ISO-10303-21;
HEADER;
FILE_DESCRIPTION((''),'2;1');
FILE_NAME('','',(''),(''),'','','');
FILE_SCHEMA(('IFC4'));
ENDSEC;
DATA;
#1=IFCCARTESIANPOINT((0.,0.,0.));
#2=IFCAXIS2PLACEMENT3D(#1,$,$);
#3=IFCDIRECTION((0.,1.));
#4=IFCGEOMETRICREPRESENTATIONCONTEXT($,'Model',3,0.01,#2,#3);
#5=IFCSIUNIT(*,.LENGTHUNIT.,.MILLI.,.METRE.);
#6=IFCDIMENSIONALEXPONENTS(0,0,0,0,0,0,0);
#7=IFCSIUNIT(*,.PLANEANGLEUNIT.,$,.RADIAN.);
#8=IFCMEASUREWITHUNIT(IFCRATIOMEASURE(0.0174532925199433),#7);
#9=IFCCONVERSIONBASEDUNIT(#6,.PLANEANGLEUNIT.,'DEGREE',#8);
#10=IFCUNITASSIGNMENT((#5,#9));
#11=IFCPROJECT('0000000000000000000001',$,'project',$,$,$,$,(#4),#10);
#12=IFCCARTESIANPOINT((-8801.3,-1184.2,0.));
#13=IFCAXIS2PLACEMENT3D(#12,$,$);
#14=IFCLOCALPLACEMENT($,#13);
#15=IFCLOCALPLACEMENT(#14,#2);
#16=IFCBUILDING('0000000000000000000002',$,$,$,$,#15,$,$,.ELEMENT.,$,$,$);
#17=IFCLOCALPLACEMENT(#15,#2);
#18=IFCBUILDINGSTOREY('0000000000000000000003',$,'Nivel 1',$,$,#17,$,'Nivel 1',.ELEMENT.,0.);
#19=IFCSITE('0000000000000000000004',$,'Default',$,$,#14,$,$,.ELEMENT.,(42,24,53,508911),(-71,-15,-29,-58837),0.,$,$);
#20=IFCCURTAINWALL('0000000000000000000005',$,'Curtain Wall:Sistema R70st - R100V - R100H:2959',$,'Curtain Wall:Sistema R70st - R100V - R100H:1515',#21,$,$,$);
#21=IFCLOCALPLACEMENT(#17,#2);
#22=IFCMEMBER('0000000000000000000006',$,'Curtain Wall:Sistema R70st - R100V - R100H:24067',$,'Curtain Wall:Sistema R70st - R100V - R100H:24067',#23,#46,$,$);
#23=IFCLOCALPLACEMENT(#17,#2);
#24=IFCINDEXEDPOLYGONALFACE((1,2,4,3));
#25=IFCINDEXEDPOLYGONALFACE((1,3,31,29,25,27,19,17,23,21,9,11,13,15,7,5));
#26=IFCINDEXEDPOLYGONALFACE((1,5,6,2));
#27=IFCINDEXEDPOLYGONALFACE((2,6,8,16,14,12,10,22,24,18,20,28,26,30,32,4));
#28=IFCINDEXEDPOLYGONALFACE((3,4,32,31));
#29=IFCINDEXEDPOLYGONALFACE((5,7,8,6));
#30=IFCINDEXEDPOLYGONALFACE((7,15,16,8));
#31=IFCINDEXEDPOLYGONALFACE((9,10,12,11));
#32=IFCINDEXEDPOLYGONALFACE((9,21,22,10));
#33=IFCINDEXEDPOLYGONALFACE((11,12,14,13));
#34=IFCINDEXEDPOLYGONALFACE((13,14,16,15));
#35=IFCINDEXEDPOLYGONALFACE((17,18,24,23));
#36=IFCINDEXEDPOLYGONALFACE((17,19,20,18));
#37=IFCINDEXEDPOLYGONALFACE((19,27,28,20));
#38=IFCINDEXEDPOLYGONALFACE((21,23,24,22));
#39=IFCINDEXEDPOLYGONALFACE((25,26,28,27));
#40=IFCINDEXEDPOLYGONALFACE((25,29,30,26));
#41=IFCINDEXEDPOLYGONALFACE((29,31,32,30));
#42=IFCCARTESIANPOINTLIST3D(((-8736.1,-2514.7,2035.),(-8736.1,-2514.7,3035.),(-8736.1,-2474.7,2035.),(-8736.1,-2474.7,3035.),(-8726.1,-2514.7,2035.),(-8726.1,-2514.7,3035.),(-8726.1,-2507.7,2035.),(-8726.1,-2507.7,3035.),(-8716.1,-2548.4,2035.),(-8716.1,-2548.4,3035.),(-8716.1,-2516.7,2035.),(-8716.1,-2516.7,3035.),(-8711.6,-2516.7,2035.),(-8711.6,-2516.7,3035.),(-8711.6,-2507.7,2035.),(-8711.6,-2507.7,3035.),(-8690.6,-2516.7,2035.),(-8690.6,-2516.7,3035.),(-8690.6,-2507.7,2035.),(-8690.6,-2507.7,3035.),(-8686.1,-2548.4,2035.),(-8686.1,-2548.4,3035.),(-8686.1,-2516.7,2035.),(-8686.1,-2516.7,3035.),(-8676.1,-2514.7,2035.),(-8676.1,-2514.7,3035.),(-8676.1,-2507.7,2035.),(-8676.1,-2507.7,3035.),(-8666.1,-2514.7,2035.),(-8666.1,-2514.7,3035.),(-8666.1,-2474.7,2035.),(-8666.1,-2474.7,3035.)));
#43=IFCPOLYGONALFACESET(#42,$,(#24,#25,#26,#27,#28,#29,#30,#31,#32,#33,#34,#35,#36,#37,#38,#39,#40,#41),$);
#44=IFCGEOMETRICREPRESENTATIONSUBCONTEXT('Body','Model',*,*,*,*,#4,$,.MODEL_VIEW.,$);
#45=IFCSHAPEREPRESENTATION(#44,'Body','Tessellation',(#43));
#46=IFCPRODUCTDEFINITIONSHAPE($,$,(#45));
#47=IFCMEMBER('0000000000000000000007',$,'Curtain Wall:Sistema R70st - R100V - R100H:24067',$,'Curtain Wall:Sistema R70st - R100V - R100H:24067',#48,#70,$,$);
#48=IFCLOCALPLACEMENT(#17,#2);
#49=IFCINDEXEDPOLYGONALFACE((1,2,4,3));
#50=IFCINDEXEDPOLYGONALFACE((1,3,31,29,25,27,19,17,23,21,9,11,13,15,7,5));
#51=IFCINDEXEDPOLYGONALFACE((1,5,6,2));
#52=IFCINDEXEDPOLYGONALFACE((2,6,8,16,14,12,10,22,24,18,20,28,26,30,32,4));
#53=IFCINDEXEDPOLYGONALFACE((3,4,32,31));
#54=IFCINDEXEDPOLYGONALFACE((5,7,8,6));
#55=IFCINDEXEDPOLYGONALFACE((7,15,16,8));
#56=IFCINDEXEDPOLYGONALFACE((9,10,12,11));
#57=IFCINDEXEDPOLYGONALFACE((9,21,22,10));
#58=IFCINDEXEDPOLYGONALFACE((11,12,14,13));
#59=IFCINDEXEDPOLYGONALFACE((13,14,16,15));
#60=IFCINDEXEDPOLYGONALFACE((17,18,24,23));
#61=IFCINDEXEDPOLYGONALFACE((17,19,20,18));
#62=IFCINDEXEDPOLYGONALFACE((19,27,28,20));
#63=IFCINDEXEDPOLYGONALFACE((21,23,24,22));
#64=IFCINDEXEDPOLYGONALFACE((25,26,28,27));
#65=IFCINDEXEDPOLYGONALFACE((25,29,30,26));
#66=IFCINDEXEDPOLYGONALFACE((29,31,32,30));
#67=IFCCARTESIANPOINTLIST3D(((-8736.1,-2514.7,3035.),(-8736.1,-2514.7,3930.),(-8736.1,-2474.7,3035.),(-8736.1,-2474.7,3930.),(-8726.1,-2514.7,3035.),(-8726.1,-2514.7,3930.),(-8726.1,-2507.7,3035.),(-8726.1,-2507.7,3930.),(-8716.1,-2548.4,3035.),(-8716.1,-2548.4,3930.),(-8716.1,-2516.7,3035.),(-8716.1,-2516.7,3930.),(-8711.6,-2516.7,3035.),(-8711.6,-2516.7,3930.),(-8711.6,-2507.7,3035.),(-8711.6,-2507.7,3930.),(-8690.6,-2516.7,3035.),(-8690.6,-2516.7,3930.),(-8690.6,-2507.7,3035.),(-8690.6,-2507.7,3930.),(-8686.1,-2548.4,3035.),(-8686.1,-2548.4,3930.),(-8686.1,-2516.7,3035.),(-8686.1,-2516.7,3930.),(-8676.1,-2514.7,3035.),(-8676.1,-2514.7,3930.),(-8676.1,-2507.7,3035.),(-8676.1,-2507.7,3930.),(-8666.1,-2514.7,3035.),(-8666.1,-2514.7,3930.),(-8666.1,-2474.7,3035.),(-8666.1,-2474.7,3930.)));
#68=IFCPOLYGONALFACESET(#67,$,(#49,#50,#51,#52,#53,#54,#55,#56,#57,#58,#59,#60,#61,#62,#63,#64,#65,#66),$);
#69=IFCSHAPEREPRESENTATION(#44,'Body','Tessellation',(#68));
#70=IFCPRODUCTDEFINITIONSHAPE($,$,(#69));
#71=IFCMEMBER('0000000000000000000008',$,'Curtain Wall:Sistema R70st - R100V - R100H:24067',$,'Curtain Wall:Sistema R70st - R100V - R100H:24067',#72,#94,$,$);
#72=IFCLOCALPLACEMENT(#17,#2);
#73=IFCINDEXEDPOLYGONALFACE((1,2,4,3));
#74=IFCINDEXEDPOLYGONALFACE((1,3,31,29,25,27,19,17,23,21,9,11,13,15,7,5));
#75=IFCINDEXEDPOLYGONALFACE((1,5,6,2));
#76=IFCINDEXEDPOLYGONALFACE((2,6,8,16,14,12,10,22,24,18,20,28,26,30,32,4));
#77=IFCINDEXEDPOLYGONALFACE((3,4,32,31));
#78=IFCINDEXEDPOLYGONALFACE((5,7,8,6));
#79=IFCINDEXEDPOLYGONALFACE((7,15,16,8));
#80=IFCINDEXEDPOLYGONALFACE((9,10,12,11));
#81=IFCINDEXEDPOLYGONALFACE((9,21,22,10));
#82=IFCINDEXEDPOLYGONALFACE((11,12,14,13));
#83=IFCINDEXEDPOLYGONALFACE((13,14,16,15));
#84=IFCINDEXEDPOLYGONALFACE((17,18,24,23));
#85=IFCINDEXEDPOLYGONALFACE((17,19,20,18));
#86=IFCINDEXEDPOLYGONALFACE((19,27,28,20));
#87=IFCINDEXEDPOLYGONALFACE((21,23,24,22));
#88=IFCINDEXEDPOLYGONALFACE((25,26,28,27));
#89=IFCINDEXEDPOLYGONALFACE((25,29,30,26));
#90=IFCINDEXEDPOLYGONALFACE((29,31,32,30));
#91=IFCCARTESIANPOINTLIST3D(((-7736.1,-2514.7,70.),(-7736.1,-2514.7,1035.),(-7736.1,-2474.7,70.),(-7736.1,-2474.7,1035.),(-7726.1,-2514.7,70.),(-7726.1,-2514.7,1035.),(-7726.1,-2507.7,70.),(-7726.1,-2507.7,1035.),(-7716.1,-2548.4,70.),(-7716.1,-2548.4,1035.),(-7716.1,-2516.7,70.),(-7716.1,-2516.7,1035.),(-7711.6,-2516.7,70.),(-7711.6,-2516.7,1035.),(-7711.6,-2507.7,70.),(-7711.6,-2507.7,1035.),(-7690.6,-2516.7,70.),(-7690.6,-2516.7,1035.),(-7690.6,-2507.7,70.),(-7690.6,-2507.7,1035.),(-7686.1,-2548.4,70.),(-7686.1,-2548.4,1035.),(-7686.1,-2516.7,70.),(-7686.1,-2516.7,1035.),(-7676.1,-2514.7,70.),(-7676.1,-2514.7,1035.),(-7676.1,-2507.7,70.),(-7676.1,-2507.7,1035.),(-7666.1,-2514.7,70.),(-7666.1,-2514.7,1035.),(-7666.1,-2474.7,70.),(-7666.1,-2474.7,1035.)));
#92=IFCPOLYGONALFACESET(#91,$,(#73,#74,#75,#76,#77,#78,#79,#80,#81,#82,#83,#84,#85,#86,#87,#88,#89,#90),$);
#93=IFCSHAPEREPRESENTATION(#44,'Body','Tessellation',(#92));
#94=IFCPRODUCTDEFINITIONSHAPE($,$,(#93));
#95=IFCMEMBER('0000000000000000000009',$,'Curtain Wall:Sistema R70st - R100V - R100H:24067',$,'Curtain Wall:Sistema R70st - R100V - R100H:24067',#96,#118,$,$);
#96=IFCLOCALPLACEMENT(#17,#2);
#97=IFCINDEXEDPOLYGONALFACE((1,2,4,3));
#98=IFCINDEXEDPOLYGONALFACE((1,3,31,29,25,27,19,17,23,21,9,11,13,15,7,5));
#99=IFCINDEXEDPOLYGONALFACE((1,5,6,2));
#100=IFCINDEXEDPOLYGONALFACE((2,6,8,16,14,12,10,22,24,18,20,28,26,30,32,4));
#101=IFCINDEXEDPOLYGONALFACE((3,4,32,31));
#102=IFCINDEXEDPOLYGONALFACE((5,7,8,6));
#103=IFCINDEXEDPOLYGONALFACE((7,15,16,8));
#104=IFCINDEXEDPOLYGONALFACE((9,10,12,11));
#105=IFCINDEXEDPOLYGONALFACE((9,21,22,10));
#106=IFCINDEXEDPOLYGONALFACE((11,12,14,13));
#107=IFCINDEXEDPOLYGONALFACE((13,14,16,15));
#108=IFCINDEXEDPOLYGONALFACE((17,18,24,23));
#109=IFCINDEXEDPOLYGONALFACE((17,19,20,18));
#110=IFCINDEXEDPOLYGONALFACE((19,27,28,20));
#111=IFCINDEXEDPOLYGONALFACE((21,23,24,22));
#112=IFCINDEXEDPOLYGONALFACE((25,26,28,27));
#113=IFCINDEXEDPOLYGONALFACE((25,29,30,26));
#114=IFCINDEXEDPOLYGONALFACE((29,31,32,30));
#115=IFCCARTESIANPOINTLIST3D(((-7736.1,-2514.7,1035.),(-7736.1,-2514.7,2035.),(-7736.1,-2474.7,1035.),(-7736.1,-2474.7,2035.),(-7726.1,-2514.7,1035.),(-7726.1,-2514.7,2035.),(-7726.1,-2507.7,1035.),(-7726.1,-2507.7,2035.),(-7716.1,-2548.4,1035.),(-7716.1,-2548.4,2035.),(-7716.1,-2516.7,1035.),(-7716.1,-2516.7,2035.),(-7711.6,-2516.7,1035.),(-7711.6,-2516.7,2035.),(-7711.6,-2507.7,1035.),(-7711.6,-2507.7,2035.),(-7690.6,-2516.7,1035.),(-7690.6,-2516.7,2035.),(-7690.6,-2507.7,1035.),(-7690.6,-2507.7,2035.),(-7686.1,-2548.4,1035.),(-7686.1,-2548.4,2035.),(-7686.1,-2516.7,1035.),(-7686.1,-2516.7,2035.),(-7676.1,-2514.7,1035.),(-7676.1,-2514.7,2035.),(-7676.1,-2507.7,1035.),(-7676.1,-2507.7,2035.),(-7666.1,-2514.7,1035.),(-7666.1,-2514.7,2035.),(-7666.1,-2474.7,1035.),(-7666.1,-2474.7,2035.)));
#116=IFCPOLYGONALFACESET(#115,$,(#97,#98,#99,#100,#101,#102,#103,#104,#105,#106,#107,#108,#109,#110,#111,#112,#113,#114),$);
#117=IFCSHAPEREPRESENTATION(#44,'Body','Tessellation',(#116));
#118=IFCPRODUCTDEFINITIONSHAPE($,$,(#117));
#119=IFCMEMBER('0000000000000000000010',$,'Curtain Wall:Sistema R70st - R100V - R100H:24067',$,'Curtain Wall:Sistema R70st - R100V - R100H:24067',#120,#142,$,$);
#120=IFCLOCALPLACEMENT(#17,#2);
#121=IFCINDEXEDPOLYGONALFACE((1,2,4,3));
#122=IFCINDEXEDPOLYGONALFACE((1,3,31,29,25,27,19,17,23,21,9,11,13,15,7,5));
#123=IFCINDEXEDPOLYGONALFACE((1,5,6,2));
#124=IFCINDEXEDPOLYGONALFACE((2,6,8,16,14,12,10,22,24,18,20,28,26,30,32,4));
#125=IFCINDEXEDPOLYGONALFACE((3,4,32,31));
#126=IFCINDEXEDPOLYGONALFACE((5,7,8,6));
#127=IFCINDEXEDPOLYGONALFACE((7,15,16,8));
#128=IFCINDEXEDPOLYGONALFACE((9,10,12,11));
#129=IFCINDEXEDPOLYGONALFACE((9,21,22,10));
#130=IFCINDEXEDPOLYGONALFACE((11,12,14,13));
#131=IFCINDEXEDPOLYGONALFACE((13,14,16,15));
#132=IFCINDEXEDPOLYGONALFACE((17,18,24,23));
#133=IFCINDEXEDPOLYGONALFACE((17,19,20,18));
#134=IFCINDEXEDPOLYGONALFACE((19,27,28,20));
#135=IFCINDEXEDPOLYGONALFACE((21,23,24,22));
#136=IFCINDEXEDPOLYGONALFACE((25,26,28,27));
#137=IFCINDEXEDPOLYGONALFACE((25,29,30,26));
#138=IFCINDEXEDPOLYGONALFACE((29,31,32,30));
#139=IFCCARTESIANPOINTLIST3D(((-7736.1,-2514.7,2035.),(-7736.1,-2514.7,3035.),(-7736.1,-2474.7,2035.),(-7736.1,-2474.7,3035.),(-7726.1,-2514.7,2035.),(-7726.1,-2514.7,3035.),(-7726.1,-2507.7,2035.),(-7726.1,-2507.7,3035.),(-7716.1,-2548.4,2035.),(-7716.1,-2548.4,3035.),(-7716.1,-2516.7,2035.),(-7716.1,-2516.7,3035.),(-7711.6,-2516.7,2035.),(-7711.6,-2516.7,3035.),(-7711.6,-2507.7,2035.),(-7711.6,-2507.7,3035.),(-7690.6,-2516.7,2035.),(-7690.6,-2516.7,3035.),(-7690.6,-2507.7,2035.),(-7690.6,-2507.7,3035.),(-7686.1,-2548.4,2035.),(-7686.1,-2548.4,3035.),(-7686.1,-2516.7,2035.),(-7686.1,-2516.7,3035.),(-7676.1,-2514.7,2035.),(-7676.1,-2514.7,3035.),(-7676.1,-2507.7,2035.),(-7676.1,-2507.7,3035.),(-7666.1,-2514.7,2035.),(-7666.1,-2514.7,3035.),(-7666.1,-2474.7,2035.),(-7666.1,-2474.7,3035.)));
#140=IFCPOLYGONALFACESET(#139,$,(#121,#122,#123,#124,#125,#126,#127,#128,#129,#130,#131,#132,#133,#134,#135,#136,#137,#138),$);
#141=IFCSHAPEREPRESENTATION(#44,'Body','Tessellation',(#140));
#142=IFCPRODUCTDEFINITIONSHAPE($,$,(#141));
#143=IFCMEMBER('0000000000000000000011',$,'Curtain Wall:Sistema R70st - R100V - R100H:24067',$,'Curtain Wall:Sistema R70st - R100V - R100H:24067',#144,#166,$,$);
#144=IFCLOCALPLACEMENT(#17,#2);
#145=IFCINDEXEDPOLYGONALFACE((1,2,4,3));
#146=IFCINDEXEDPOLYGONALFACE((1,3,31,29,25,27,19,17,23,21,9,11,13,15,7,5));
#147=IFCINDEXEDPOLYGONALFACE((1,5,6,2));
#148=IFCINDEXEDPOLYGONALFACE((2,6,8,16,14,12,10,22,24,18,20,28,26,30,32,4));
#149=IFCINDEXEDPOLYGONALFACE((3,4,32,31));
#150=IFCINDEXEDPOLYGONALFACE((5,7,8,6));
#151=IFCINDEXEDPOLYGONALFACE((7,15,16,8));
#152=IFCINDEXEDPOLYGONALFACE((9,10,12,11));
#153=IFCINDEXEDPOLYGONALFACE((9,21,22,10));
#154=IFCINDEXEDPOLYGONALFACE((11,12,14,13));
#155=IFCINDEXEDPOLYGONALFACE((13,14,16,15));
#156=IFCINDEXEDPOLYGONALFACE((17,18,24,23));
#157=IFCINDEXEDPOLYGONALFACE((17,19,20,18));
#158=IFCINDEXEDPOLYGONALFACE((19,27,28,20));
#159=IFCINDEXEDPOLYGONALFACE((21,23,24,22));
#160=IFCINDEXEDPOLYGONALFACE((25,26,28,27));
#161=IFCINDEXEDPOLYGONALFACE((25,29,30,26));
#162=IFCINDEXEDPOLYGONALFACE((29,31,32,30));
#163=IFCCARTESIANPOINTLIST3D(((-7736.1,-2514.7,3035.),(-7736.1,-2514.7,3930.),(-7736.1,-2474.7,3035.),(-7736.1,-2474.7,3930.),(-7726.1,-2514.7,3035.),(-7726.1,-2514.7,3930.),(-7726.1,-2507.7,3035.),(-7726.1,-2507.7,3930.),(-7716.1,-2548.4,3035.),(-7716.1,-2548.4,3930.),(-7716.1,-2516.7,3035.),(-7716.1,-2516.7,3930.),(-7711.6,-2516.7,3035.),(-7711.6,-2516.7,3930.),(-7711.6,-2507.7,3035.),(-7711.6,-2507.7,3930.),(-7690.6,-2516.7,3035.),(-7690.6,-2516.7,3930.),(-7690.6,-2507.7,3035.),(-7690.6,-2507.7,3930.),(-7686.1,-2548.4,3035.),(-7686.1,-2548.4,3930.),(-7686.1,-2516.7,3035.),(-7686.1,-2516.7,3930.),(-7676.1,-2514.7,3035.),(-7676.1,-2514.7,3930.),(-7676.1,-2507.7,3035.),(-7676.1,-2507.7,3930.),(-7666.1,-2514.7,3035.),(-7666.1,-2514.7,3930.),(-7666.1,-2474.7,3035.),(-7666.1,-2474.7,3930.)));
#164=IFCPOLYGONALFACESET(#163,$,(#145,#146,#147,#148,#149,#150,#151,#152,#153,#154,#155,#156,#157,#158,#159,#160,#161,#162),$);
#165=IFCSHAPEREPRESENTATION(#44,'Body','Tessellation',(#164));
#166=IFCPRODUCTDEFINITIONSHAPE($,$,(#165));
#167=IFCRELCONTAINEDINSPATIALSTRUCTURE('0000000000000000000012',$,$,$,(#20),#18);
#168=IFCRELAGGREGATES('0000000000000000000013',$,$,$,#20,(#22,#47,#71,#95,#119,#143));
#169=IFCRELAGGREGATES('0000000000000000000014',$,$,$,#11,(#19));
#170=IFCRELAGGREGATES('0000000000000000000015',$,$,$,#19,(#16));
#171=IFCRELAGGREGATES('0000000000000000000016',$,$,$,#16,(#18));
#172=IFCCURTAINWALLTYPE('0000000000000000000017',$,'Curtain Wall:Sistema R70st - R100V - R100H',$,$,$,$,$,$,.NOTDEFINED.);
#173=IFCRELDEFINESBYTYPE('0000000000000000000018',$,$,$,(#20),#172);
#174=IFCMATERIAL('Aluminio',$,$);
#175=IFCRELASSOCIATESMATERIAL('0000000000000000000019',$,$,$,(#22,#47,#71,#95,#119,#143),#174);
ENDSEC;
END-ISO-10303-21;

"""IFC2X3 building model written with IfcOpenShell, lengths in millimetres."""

from ifc_helpers import new_model, entity, si_unit, converted_unit, direction, frame, origin, place, context, subcontext, project, spatial, polyline, outline, extrude, material, type_object, element, aggregate, save


model = new_model("IFC2X3")

# Units and contexts
model_context = context("Model", 3, precision=0.01, world=origin(), true_north=direction((0.0, 1.0)))
body_context = subcontext(model_context, "Body", "Model", "MODEL_VIEW")
ifc_project = project(units=[si_unit("LENGTHUNIT", "METRE", prefix="MILLI"), converted_unit("PLANEANGLEUNIT", "DEGREE", entity("IfcRatioMeasure", 0.0174532925199433), si_unit("PLANEANGLEUNIT", "RADIAN"), dimensions=[0, 0, 0, 0, 0, 0, 0])], contexts=[model_context])

# Site, building, storey
site_placement = place(None, frame((-8801.3, -1184.2, 0.0)))
site = spatial("IfcSite", under=ifc_project, at=site_placement, Name="Default", CompositionType="ELEMENT", RefLatitude=(42, 24, 53, 508911), RefLongitude=(-71, -15, -29, -58837), RefElevation=0.0)
building_placement = place(site_placement, origin())
building = spatial("IfcBuilding", under=site, at=building_placement, CompositionType="ELEMENT")
storey_placement = place(building_placement, origin())
storey = spatial("IfcBuildingStorey", under=building, at=storey_placement, Name="Nivel 1", LongName="Nivel 1", CompositionType="ELEMENT", Elevation=0.0)

# Curtain wall, members
curtain_wall_type = type_object("IfcCurtainWallType", Name="Curtain Wall:Sistema R70st - R100V - R100H", PredefinedType="NOTDEFINED")
curtain_wall_placement = place(storey_placement, origin())
curtain_wall = element("IfcCurtainWall", 1, at=curtain_wall_placement, inside=storey, type_object=curtain_wall_type, Name="Curtain Wall:Sistema R70st - R100V - R100H:2959", ObjectType="Curtain Wall:Sistema R70st - R100V - R100H:1515")
ifc_material = material(Name="Aluminio")
member_1_placement = place(curtain_wall_placement, origin())
member_1 = element("IfcMember", 2, at=member_1_placement, material=ifc_material, Name="Curtain Wall:Sistema R70st - R100V - R100H:24067", ObjectType="Curtain Wall:Sistema R70st - R100V - R100H:24067", context=body_context, shape_type="SweptSolid", body=[
    extrude(outline(polyline([(-35.0, -38.0), (35.0, -38.0), (35.0, 2.0), (25.0, 2.0), (25.0, -5.0), (10.5, -5.0), (10.5, 4.0), (15.0, 4.0), (15.0, 35.7), (-15.0, 35.7), (-15.0, 4.0), (-10.5, 4.0), (-10.5, -5.0), (-25.0, -5.0), (-25.0, 2.0), (-35.0, 2.0), (-35.0, -38.0)])), frame((-8701.1, -2512.7, 2035.0), z_axis=(0.0, 0.0, 1.0), x_axis=(-1.0, 0.0, 0.0)), (0.0, 0.0, 1.0), 1000.0),
])
member_2_placement = place(curtain_wall_placement, origin())
member_2 = element("IfcMember", 3, at=member_2_placement, material=ifc_material, Name="Curtain Wall:Sistema R70st - R100V - R100H:24067", ObjectType="Curtain Wall:Sistema R70st - R100V - R100H:24067", context=body_context, shape_type="SweptSolid", body=[
    extrude(outline(polyline([(-35.0, -38.0), (35.0, -38.0), (35.0, 2.0), (25.0, 2.0), (25.0, -5.0), (10.5, -5.0), (10.5, 4.0), (15.0, 4.0), (15.0, 35.7), (-15.0, 35.7), (-15.0, 4.0), (-10.5, 4.0), (-10.5, -5.0), (-25.0, -5.0), (-25.0, 2.0), (-35.0, 2.0), (-35.0, -38.0)])), frame((-8701.1, -2512.7, 3035.0), z_axis=(0.0, 0.0, 1.0), x_axis=(-1.0, 0.0, 0.0)), (0.0, 0.0, 1.0), 895.0),
])
member_3_placement = place(curtain_wall_placement, origin())
member_3 = element("IfcMember", 4, at=member_3_placement, material=ifc_material, Name="Curtain Wall:Sistema R70st - R100V - R100H:24067", ObjectType="Curtain Wall:Sistema R70st - R100V - R100H:24067", context=body_context, shape_type="SweptSolid", body=[
    extrude(outline(polyline([(-35.0, -38.0), (35.0, -38.0), (35.0, 2.0), (25.0, 2.0), (25.0, -5.0), (10.5, -5.0), (10.5, 4.0), (15.0, 4.0), (15.0, 35.7), (-15.0, 35.7), (-15.0, 4.0), (-10.5, 4.0), (-10.5, -5.0), (-25.0, -5.0), (-25.0, 2.0), (-35.0, 2.0), (-35.0, -38.0)])), frame((-7701.1, -2512.7, 70.0), z_axis=(0.0, 0.0, 1.0), x_axis=(-1.0, 0.0, 0.0)), (0.0, 0.0, 1.0), 965.0),
])
member_4_placement = place(curtain_wall_placement, origin())
member_4 = element("IfcMember", 5, at=member_4_placement, material=ifc_material, Name="Curtain Wall:Sistema R70st - R100V - R100H:24067", ObjectType="Curtain Wall:Sistema R70st - R100V - R100H:24067", context=body_context, shape_type="SweptSolid", body=[
    extrude(outline(polyline([(-35.0, -38.0), (35.0, -38.0), (35.0, 2.0), (25.0, 2.0), (25.0, -5.0), (10.5, -5.0), (10.5, 4.0), (15.0, 4.0), (15.0, 35.7), (-15.0, 35.7), (-15.0, 4.0), (-10.5, 4.0), (-10.5, -5.0), (-25.0, -5.0), (-25.0, 2.0), (-35.0, 2.0), (-35.0, -38.0)])), frame((-7701.1, -2512.7, 1035.0), z_axis=(0.0, 0.0, 1.0), x_axis=(-1.0, 0.0, 0.0)), (0.0, 0.0, 1.0), 1000.0),
])
member_5_placement = place(curtain_wall_placement, origin())
member_5 = element("IfcMember", 6, at=member_5_placement, material=ifc_material, Name="Curtain Wall:Sistema R70st - R100V - R100H:24067", ObjectType="Curtain Wall:Sistema R70st - R100V - R100H:24067", context=body_context, shape_type="SweptSolid", body=[
    extrude(outline(polyline([(-35.0, -38.0), (35.0, -38.0), (35.0, 2.0), (25.0, 2.0), (25.0, -5.0), (10.5, -5.0), (10.5, 4.0), (15.0, 4.0), (15.0, 35.7), (-15.0, 35.7), (-15.0, 4.0), (-10.5, 4.0), (-10.5, -5.0), (-25.0, -5.0), (-25.0, 2.0), (-35.0, 2.0), (-35.0, -38.0)])), frame((-7701.1, -2512.7, 2035.0), z_axis=(0.0, 0.0, 1.0), x_axis=(-1.0, 0.0, 0.0)), (0.0, 0.0, 1.0), 1000.0),
])
member_6_placement = place(curtain_wall_placement, origin())
member_6 = element("IfcMember", 7, at=member_6_placement, material=ifc_material, Name="Curtain Wall:Sistema R70st - R100V - R100H:24067", ObjectType="Curtain Wall:Sistema R70st - R100V - R100H:24067", context=body_context, shape_type="SweptSolid", body=[
    extrude(outline(polyline([(-35.0, -38.0), (35.0, -38.0), (35.0, 2.0), (25.0, 2.0), (25.0, -5.0), (10.5, -5.0), (10.5, 4.0), (15.0, 4.0), (15.0, 35.7), (-15.0, 35.7), (-15.0, 4.0), (-10.5, 4.0), (-10.5, -5.0), (-25.0, -5.0), (-25.0, 2.0), (-35.0, 2.0), (-35.0, -38.0)])), frame((-7701.1, -2512.7, 3035.0), z_axis=(0.0, 0.0, 1.0), x_axis=(-1.0, 0.0, 0.0)), (0.0, 0.0, 1.0), 895.0),
])
aggregate(curtain_wall, [member_1, member_2, member_3, member_4, member_5, member_6])

save(model, "model.ifc")
